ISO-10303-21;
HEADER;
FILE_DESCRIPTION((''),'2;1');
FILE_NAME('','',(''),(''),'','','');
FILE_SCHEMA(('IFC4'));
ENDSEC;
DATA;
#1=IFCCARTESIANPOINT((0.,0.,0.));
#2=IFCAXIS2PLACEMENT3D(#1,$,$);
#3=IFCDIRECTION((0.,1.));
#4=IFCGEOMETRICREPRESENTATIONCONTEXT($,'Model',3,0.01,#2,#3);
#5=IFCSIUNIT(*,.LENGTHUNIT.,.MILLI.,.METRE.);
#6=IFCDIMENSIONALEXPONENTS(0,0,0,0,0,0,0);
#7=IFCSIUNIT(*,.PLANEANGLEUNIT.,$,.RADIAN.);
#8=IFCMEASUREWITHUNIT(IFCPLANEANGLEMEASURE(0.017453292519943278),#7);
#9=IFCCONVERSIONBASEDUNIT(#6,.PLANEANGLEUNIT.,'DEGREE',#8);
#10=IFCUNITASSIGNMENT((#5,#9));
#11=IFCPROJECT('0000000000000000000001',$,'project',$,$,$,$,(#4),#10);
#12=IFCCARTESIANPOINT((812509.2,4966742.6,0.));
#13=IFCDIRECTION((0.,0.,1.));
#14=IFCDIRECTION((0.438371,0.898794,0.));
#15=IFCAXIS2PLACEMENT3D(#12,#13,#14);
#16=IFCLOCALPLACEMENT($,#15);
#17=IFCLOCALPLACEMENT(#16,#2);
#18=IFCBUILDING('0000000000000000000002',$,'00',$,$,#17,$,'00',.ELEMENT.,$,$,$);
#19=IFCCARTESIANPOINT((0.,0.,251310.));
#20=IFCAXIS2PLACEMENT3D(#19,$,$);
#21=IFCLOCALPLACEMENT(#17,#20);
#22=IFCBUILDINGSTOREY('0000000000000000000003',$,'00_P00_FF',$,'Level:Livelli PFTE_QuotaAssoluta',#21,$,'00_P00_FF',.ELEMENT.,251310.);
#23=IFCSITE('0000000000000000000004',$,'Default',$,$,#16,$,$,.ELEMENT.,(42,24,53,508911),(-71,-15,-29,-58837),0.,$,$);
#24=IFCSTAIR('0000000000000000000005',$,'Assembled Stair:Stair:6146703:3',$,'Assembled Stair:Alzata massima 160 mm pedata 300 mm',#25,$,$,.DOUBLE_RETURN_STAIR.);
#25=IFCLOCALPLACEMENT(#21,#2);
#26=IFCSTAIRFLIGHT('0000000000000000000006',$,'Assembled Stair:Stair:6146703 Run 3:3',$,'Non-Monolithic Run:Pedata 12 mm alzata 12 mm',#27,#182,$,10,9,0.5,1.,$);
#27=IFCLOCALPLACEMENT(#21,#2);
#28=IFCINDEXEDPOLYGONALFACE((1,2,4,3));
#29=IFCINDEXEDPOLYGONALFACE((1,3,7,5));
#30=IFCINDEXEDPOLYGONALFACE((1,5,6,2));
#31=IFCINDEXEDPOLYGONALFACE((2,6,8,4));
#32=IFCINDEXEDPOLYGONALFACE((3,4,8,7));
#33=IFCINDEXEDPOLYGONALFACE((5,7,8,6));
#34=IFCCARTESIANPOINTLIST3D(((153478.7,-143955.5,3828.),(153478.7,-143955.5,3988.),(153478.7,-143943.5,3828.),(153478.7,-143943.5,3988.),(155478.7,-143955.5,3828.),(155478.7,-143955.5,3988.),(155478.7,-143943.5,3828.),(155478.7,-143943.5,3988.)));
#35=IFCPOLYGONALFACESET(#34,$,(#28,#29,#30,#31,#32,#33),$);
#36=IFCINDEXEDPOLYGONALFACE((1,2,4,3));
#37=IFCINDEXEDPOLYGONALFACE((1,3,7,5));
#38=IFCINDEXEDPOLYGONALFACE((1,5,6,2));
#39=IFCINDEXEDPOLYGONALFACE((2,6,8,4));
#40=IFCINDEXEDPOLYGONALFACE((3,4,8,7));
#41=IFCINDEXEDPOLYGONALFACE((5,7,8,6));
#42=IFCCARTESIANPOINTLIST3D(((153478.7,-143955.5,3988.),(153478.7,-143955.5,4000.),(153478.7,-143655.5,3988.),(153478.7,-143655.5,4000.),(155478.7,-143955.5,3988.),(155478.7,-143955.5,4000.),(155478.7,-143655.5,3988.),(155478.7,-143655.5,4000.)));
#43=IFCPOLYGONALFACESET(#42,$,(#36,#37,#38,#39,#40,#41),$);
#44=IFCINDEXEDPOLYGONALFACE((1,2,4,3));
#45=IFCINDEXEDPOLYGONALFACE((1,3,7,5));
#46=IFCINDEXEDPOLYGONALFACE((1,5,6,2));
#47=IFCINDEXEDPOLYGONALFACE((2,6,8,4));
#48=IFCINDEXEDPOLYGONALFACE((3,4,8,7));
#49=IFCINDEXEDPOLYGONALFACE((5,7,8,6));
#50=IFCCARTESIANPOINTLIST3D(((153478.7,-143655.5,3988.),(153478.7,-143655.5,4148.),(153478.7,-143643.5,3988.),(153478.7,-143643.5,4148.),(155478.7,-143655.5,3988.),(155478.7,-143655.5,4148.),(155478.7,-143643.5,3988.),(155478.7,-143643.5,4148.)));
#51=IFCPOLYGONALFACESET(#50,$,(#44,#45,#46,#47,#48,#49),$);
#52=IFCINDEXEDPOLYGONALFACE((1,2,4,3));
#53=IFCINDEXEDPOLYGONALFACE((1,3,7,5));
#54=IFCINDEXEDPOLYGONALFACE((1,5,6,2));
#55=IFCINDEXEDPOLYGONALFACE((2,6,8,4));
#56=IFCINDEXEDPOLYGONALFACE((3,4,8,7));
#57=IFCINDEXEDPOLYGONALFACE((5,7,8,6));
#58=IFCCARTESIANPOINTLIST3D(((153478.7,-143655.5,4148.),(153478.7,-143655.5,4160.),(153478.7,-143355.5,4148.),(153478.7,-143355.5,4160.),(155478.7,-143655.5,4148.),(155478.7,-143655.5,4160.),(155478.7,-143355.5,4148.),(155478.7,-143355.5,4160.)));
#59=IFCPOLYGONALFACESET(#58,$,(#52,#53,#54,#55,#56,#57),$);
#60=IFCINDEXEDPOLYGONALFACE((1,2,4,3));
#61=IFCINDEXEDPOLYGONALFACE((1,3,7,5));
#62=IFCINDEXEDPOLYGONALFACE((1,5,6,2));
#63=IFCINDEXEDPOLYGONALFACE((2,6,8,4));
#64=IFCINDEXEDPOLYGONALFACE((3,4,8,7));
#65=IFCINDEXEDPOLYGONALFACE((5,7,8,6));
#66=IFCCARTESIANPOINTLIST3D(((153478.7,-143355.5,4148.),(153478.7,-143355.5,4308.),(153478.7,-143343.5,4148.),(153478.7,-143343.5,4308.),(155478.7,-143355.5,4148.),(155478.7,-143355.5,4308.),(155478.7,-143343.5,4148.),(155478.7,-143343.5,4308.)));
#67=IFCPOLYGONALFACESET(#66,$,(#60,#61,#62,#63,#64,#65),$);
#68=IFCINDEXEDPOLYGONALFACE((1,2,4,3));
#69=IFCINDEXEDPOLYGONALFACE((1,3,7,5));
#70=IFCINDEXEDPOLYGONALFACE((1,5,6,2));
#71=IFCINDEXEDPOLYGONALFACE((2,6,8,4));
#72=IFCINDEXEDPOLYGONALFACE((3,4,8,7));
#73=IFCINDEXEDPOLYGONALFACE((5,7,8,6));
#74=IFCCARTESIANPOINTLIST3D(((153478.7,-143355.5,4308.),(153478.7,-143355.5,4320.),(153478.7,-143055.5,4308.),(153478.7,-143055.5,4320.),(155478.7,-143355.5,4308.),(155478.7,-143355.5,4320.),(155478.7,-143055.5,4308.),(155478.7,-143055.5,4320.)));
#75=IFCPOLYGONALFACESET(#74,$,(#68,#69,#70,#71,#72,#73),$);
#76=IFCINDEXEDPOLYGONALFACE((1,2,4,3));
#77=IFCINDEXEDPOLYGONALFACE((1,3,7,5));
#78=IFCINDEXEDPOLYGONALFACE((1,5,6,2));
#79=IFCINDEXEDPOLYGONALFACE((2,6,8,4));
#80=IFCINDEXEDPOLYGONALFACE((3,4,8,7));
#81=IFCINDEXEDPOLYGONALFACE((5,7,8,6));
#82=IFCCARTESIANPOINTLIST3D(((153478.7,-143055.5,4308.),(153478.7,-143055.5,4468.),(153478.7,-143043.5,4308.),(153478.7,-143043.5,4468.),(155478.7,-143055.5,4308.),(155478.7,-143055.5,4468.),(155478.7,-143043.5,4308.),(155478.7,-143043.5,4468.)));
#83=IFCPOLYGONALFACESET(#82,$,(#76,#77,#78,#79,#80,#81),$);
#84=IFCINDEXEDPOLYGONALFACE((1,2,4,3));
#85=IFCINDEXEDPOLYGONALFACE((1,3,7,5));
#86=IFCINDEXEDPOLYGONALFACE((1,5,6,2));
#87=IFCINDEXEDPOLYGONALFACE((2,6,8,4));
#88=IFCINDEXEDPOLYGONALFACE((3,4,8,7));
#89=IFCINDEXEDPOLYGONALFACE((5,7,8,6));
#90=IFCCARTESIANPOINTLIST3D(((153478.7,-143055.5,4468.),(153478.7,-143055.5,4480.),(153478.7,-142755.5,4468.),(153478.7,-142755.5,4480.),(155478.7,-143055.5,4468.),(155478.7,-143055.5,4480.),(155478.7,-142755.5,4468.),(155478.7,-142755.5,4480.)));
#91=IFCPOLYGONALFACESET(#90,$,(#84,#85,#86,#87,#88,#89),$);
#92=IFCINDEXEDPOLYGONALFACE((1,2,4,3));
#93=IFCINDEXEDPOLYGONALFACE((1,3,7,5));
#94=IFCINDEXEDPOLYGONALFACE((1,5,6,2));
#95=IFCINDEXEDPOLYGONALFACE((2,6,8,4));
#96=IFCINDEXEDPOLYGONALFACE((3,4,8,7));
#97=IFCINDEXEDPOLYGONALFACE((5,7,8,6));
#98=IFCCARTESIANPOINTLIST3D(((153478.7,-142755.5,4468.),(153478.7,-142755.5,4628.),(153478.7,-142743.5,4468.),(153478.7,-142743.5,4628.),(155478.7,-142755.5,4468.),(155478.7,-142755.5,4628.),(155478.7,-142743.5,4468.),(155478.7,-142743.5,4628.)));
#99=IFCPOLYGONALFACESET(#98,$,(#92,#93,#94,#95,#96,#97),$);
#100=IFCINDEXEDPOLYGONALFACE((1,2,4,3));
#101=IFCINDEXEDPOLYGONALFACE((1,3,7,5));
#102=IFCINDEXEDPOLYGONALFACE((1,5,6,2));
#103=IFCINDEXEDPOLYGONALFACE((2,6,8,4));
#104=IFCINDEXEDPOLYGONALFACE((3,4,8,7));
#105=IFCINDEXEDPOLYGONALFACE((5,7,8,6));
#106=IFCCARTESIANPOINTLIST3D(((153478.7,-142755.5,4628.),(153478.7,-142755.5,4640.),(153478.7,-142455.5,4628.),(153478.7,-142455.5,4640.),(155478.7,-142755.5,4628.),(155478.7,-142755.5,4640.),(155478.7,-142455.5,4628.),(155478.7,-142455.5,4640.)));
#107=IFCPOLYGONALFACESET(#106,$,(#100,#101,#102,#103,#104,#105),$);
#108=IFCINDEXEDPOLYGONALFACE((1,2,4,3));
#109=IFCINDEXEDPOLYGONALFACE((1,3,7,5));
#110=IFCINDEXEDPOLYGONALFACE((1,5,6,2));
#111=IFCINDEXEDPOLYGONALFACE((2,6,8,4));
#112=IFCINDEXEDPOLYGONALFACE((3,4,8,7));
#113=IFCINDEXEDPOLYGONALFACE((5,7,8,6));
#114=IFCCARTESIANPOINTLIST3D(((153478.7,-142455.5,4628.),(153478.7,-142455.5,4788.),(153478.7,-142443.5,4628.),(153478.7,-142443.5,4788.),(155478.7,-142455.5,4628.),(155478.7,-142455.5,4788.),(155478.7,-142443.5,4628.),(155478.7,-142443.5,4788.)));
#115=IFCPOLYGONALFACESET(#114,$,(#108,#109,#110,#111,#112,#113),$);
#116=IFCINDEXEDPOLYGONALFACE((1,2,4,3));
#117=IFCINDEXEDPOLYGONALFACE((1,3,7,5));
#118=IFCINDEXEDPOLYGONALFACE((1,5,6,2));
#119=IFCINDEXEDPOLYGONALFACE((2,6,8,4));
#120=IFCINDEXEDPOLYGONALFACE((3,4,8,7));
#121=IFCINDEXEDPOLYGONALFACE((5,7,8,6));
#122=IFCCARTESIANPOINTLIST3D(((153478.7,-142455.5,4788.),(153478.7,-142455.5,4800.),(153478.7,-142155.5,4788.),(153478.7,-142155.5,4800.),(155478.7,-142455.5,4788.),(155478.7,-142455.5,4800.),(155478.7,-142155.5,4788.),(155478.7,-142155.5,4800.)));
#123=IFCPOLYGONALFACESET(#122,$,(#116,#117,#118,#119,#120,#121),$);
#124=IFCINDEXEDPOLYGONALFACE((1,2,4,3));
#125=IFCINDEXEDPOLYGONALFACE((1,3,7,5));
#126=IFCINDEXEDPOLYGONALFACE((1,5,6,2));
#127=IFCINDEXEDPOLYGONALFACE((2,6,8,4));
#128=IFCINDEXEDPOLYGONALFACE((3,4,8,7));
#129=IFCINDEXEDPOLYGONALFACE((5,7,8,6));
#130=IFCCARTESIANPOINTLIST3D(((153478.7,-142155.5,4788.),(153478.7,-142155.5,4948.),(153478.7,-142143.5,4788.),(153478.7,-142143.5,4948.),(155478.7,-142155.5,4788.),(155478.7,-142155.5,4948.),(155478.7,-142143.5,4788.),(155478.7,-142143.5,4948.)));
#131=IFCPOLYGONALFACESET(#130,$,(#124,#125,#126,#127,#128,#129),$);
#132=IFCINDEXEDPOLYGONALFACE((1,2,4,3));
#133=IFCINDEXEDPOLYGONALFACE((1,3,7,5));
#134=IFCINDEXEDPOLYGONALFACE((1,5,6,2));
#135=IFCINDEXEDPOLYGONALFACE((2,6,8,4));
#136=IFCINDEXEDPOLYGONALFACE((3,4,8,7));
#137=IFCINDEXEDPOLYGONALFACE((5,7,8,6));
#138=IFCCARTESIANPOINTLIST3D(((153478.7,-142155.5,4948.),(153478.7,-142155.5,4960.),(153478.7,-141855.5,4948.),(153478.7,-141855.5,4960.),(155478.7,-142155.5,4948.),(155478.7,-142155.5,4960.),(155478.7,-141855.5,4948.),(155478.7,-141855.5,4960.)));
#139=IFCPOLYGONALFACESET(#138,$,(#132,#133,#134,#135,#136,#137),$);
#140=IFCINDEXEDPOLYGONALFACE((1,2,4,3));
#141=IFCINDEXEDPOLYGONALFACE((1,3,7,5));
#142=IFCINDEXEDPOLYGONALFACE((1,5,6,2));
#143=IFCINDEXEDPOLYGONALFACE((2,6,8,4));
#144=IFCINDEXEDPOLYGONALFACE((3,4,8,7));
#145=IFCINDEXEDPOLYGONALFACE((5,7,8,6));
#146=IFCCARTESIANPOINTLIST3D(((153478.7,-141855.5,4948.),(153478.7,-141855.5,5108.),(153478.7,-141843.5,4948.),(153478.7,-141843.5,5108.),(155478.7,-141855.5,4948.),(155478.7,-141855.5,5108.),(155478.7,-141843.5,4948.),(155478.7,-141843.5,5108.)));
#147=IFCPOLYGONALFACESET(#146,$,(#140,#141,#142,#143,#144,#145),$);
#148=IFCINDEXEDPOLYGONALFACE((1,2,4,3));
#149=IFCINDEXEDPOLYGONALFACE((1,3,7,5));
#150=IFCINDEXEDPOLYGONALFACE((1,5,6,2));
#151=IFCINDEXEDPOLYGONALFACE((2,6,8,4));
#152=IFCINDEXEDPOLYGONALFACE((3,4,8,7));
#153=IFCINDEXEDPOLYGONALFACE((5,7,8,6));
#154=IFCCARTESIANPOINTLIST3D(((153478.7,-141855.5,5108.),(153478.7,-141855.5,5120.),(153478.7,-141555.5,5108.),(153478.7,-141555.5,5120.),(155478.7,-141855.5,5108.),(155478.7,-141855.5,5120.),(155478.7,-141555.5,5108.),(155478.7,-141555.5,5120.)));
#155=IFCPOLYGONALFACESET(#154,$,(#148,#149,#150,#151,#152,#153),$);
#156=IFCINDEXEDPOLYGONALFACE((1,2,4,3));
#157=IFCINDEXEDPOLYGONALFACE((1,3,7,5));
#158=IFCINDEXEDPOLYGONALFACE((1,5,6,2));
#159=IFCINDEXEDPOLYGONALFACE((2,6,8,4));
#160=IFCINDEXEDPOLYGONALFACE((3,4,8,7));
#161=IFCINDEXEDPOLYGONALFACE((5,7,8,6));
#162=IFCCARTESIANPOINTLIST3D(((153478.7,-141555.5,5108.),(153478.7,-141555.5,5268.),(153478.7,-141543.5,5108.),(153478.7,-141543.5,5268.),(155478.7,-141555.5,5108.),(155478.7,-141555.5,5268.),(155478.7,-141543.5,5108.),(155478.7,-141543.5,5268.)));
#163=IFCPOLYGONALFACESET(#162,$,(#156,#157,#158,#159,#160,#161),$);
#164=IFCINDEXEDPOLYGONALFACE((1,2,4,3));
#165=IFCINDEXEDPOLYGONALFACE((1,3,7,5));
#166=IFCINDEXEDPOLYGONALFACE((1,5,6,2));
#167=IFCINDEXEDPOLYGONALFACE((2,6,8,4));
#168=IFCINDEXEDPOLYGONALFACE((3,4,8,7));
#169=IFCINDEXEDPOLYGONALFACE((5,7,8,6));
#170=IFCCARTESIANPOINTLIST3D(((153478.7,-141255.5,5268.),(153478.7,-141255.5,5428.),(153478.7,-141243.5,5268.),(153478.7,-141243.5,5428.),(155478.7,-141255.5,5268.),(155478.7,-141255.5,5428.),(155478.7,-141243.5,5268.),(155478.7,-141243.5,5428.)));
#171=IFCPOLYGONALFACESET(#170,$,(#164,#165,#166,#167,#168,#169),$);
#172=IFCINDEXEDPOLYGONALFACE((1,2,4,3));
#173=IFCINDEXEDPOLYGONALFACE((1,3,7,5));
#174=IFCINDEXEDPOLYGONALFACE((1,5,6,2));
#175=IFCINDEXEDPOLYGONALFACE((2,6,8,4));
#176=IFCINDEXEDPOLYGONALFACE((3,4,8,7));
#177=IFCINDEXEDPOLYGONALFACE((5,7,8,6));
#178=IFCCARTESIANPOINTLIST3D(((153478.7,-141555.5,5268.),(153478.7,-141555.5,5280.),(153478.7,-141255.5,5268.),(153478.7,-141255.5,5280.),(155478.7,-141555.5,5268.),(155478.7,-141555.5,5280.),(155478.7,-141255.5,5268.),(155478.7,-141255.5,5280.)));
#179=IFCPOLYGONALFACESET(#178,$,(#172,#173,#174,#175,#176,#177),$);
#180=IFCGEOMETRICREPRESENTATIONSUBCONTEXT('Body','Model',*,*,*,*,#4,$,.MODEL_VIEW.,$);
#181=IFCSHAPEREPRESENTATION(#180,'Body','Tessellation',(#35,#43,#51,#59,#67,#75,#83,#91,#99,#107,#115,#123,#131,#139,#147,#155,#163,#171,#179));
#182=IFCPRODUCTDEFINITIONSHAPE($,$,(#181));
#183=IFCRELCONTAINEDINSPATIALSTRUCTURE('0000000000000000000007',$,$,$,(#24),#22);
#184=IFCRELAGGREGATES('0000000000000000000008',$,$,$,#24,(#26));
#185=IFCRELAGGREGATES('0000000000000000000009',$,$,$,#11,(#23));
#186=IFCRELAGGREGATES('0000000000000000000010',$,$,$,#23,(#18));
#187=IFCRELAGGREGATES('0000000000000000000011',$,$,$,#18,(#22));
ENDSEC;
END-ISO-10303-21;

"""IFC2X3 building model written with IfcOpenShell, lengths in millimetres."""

from ifc_helpers import new_model, entity, si_unit, converted_unit, direction, frame, frame_2d, origin, place, context, subcontext, project, spatial, rectangle, extrude, element, aggregate, save


model = new_model("IFC2X3")

# Units and contexts
model_context = context("Model", 3, precision=0.01, world=origin(), true_north=direction((0.0, 1.0)))
body_context = subcontext(model_context, "Body", "Model", "MODEL_VIEW")
ifc_project = project(units=[si_unit("LENGTHUNIT", "METRE", prefix="MILLI"), converted_unit("PLANEANGLEUNIT", "DEGREE", entity("IfcPlaneAngleMeasure", 0.017453292519943278), si_unit("PLANEANGLEUNIT", "RADIAN"), dimensions=[0, 0, 0, 0, 0, 0, 0])], contexts=[model_context])

# Site, building, storey
site_placement = place(None, frame((812509.2, 4966742.6, 0.0), z_axis=(0.0, 0.0, 1.0), x_axis=(0.438371, 0.898794, 0.0)))
site = spatial("IfcSite", under=ifc_project, at=site_placement, Name="Default", CompositionType="ELEMENT", RefLatitude=(42, 24, 53, 508911), RefLongitude=(-71, -15, -29, -58837), RefElevation=0.0)
building_placement = place(site_placement, origin())
building = spatial("IfcBuilding", under=site, at=building_placement, Name="00", LongName="00", CompositionType="ELEMENT")
storey_placement = place(building_placement, frame((0.0, 0.0, 251310.0)))
storey = spatial("IfcBuildingStorey", under=building, at=storey_placement, Name="00_P00_FF", ObjectType="Level:Livelli PFTE_QuotaAssoluta", LongName="00_P00_FF", CompositionType="ELEMENT", Elevation=251310.0)

# Stair
stair_1_placement = place(storey_placement, origin())
stair_1 = element("IfcStair", 1, at=stair_1_placement, inside=storey, Name="Assembled Stair:Stair:6146703:3", ObjectType="Assembled Stair:Alzata massima 160 mm pedata 300 mm", ShapeType="DOUBLE_RETURN_STAIR")

# Stair flight
stair_flight_1_placement = place(stair_1_placement, origin())
stair_flight_1 = element("IfcStairFlight", 2, at=stair_flight_1_placement, Name="Assembled Stair:Stair:6146703 Run 3:3", ObjectType="Non-Monolithic Run:Pedata 12 mm alzata 12 mm", NumberOfRiser=10, NumberOfTreads=9, RiserHeight=0.5, TreadLength=1.0, context=body_context, shape_type="SweptSolid", body=[
    extrude(rectangle(XDim=2000.0, YDim=12.0, at=frame_2d((0.0, 0.0), x_axis=(1.0, 0.0))), frame((154478.7, -143949.5, 3828.0), z_axis=(0.0, 0.0, 1.0), x_axis=(-1.0, 0.0, 0.0)), (0.0, 0.0, 1.0), 160.0),
    extrude(rectangle(XDim=300.0, YDim=2000.0, at=frame_2d((0.0, 0.0), x_axis=(1.0, 0.0))), frame((154478.7, -143805.5, 3988.0), z_axis=(0.0, 0.0, 1.0), x_axis=(0.0, -1.0, 0.0)), (0.0, 0.0, 1.0), 12.0),
    extrude(rectangle(XDim=2000.0, YDim=12.0, at=frame_2d((0.0, 0.0), x_axis=(1.0, 0.0))), frame((154478.7, -143649.5, 3988.0), z_axis=(0.0, 0.0, 1.0), x_axis=(-1.0, 0.0, 0.0)), (0.0, 0.0, 1.0), 160.0),
    extrude(rectangle(XDim=300.0, YDim=2000.0, at=frame_2d((0.0, 0.0), x_axis=(1.0, 0.0))), frame((154478.7, -143505.5, 4148.0), z_axis=(0.0, 0.0, 1.0), x_axis=(0.0, -1.0, 0.0)), (0.0, 0.0, 1.0), 12.0),
    extrude(rectangle(XDim=2000.0, YDim=12.0, at=frame_2d((0.0, 0.0), x_axis=(1.0, 0.0))), frame((154478.7, -143349.5, 4148.0), z_axis=(0.0, 0.0, 1.0), x_axis=(-1.0, 0.0, 0.0)), (0.0, 0.0, 1.0), 160.0),
    extrude(rectangle(XDim=300.0, YDim=2000.0, at=frame_2d((0.0, 0.0), x_axis=(1.0, 0.0))), frame((154478.7, -143205.5, 4308.0), z_axis=(0.0, 0.0, 1.0), x_axis=(0.0, -1.0, 0.0)), (0.0, 0.0, 1.0), 12.0),
    extrude(rectangle(XDim=2000.0, YDim=12.0, at=frame_2d((0.0, 0.0), x_axis=(1.0, 0.0))), frame((154478.7, -143049.5, 4308.0), z_axis=(0.0, 0.0, 1.0), x_axis=(-1.0, 0.0, 0.0)), (0.0, 0.0, 1.0), 160.0),
    extrude(rectangle(XDim=300.0, YDim=2000.0, at=frame_2d((0.0, 0.0), x_axis=(1.0, 0.0))), frame((154478.7, -142905.5, 4468.0), z_axis=(0.0, 0.0, 1.0), x_axis=(0.0, -1.0, 0.0)), (0.0, 0.0, 1.0), 12.0),
    extrude(rectangle(XDim=2000.0, YDim=12.0, at=frame_2d((0.0, 0.0), x_axis=(1.0, 0.0))), frame((154478.7, -142749.5, 4468.0), z_axis=(0.0, 0.0, 1.0), x_axis=(-1.0, 0.0, 0.0)), (0.0, 0.0, 1.0), 160.0),
    extrude(rectangle(XDim=300.0, YDim=2000.0, at=frame_2d((0.0, 0.0), x_axis=(1.0, 0.0))), frame((154478.7, -142605.5, 4628.0), z_axis=(0.0, 0.0, 1.0), x_axis=(0.0, -1.0, 0.0)), (0.0, 0.0, 1.0), 12.0),
    extrude(rectangle(XDim=2000.0, YDim=12.0, at=frame_2d((0.0, 0.0), x_axis=(1.0, 0.0))), frame((154478.7, -142449.5, 4628.0), z_axis=(0.0, 0.0, 1.0), x_axis=(-1.0, 0.0, 0.0)), (0.0, 0.0, 1.0), 160.0),
    extrude(rectangle(XDim=300.0, YDim=2000.0, at=frame_2d((0.0, 0.0), x_axis=(1.0, 0.0))), frame((154478.7, -142305.5, 4788.0), z_axis=(0.0, 0.0, 1.0), x_axis=(0.0, -1.0, 0.0)), (0.0, 0.0, 1.0), 12.0),
    extrude(rectangle(XDim=2000.0, YDim=12.0, at=frame_2d((0.0, 0.0), x_axis=(1.0, 0.0))), frame((154478.7, -142149.5, 4788.0), z_axis=(0.0, 0.0, 1.0), x_axis=(-1.0, 0.0, 0.0)), (0.0, 0.0, 1.0), 160.0),
    extrude(rectangle(XDim=300.0, YDim=2000.0, at=frame_2d((0.0, 0.0), x_axis=(1.0, 0.0))), frame((154478.7, -142005.5, 4948.0), z_axis=(0.0, 0.0, 1.0), x_axis=(0.0, -1.0, 0.0)), (0.0, 0.0, 1.0), 12.0),
    extrude(rectangle(XDim=2000.0, YDim=12.0, at=frame_2d((0.0, 0.0), x_axis=(1.0, 0.0))), frame((154478.7, -141849.5, 4948.0), z_axis=(0.0, 0.0, 1.0), x_axis=(-1.0, 0.0, 0.0)), (0.0, 0.0, 1.0), 160.0),
    extrude(rectangle(XDim=300.0, YDim=2000.0, at=frame_2d((0.0, 0.0), x_axis=(1.0, 0.0))), frame((154478.7, -141705.5, 5108.0), z_axis=(0.0, 0.0, 1.0), x_axis=(0.0, -1.0, 0.0)), (0.0, 0.0, 1.0), 12.0),
    extrude(rectangle(XDim=2000.0, YDim=12.0, at=frame_2d((0.0, 0.0), x_axis=(1.0, 0.0))), frame((154478.7, -141549.5, 5108.0), z_axis=(0.0, 0.0, 1.0), x_axis=(-1.0, 0.0, 0.0)), (0.0, 0.0, 1.0), 160.0),
    extrude(rectangle(XDim=2000.0, YDim=12.0, at=frame_2d((0.0, 0.0), x_axis=(1.0, 0.0))), frame((154478.7, -141249.5, 5268.0), z_axis=(0.0, 0.0, 1.0), x_axis=(-1.0, 0.0, 0.0)), (0.0, 0.0, 1.0), 160.0),
    extrude(rectangle(XDim=300.0, YDim=2000.0, at=frame_2d((0.0, 0.0), x_axis=(1.0, 0.0))), frame((154478.7, -141405.5, 5268.0), z_axis=(0.0, 0.0, 1.0), x_axis=(0.0, -1.0, 0.0)), (0.0, 0.0, 1.0), 12.0),
])
aggregate(stair_1, [stair_flight_1])

save(model, "model.ifc")
